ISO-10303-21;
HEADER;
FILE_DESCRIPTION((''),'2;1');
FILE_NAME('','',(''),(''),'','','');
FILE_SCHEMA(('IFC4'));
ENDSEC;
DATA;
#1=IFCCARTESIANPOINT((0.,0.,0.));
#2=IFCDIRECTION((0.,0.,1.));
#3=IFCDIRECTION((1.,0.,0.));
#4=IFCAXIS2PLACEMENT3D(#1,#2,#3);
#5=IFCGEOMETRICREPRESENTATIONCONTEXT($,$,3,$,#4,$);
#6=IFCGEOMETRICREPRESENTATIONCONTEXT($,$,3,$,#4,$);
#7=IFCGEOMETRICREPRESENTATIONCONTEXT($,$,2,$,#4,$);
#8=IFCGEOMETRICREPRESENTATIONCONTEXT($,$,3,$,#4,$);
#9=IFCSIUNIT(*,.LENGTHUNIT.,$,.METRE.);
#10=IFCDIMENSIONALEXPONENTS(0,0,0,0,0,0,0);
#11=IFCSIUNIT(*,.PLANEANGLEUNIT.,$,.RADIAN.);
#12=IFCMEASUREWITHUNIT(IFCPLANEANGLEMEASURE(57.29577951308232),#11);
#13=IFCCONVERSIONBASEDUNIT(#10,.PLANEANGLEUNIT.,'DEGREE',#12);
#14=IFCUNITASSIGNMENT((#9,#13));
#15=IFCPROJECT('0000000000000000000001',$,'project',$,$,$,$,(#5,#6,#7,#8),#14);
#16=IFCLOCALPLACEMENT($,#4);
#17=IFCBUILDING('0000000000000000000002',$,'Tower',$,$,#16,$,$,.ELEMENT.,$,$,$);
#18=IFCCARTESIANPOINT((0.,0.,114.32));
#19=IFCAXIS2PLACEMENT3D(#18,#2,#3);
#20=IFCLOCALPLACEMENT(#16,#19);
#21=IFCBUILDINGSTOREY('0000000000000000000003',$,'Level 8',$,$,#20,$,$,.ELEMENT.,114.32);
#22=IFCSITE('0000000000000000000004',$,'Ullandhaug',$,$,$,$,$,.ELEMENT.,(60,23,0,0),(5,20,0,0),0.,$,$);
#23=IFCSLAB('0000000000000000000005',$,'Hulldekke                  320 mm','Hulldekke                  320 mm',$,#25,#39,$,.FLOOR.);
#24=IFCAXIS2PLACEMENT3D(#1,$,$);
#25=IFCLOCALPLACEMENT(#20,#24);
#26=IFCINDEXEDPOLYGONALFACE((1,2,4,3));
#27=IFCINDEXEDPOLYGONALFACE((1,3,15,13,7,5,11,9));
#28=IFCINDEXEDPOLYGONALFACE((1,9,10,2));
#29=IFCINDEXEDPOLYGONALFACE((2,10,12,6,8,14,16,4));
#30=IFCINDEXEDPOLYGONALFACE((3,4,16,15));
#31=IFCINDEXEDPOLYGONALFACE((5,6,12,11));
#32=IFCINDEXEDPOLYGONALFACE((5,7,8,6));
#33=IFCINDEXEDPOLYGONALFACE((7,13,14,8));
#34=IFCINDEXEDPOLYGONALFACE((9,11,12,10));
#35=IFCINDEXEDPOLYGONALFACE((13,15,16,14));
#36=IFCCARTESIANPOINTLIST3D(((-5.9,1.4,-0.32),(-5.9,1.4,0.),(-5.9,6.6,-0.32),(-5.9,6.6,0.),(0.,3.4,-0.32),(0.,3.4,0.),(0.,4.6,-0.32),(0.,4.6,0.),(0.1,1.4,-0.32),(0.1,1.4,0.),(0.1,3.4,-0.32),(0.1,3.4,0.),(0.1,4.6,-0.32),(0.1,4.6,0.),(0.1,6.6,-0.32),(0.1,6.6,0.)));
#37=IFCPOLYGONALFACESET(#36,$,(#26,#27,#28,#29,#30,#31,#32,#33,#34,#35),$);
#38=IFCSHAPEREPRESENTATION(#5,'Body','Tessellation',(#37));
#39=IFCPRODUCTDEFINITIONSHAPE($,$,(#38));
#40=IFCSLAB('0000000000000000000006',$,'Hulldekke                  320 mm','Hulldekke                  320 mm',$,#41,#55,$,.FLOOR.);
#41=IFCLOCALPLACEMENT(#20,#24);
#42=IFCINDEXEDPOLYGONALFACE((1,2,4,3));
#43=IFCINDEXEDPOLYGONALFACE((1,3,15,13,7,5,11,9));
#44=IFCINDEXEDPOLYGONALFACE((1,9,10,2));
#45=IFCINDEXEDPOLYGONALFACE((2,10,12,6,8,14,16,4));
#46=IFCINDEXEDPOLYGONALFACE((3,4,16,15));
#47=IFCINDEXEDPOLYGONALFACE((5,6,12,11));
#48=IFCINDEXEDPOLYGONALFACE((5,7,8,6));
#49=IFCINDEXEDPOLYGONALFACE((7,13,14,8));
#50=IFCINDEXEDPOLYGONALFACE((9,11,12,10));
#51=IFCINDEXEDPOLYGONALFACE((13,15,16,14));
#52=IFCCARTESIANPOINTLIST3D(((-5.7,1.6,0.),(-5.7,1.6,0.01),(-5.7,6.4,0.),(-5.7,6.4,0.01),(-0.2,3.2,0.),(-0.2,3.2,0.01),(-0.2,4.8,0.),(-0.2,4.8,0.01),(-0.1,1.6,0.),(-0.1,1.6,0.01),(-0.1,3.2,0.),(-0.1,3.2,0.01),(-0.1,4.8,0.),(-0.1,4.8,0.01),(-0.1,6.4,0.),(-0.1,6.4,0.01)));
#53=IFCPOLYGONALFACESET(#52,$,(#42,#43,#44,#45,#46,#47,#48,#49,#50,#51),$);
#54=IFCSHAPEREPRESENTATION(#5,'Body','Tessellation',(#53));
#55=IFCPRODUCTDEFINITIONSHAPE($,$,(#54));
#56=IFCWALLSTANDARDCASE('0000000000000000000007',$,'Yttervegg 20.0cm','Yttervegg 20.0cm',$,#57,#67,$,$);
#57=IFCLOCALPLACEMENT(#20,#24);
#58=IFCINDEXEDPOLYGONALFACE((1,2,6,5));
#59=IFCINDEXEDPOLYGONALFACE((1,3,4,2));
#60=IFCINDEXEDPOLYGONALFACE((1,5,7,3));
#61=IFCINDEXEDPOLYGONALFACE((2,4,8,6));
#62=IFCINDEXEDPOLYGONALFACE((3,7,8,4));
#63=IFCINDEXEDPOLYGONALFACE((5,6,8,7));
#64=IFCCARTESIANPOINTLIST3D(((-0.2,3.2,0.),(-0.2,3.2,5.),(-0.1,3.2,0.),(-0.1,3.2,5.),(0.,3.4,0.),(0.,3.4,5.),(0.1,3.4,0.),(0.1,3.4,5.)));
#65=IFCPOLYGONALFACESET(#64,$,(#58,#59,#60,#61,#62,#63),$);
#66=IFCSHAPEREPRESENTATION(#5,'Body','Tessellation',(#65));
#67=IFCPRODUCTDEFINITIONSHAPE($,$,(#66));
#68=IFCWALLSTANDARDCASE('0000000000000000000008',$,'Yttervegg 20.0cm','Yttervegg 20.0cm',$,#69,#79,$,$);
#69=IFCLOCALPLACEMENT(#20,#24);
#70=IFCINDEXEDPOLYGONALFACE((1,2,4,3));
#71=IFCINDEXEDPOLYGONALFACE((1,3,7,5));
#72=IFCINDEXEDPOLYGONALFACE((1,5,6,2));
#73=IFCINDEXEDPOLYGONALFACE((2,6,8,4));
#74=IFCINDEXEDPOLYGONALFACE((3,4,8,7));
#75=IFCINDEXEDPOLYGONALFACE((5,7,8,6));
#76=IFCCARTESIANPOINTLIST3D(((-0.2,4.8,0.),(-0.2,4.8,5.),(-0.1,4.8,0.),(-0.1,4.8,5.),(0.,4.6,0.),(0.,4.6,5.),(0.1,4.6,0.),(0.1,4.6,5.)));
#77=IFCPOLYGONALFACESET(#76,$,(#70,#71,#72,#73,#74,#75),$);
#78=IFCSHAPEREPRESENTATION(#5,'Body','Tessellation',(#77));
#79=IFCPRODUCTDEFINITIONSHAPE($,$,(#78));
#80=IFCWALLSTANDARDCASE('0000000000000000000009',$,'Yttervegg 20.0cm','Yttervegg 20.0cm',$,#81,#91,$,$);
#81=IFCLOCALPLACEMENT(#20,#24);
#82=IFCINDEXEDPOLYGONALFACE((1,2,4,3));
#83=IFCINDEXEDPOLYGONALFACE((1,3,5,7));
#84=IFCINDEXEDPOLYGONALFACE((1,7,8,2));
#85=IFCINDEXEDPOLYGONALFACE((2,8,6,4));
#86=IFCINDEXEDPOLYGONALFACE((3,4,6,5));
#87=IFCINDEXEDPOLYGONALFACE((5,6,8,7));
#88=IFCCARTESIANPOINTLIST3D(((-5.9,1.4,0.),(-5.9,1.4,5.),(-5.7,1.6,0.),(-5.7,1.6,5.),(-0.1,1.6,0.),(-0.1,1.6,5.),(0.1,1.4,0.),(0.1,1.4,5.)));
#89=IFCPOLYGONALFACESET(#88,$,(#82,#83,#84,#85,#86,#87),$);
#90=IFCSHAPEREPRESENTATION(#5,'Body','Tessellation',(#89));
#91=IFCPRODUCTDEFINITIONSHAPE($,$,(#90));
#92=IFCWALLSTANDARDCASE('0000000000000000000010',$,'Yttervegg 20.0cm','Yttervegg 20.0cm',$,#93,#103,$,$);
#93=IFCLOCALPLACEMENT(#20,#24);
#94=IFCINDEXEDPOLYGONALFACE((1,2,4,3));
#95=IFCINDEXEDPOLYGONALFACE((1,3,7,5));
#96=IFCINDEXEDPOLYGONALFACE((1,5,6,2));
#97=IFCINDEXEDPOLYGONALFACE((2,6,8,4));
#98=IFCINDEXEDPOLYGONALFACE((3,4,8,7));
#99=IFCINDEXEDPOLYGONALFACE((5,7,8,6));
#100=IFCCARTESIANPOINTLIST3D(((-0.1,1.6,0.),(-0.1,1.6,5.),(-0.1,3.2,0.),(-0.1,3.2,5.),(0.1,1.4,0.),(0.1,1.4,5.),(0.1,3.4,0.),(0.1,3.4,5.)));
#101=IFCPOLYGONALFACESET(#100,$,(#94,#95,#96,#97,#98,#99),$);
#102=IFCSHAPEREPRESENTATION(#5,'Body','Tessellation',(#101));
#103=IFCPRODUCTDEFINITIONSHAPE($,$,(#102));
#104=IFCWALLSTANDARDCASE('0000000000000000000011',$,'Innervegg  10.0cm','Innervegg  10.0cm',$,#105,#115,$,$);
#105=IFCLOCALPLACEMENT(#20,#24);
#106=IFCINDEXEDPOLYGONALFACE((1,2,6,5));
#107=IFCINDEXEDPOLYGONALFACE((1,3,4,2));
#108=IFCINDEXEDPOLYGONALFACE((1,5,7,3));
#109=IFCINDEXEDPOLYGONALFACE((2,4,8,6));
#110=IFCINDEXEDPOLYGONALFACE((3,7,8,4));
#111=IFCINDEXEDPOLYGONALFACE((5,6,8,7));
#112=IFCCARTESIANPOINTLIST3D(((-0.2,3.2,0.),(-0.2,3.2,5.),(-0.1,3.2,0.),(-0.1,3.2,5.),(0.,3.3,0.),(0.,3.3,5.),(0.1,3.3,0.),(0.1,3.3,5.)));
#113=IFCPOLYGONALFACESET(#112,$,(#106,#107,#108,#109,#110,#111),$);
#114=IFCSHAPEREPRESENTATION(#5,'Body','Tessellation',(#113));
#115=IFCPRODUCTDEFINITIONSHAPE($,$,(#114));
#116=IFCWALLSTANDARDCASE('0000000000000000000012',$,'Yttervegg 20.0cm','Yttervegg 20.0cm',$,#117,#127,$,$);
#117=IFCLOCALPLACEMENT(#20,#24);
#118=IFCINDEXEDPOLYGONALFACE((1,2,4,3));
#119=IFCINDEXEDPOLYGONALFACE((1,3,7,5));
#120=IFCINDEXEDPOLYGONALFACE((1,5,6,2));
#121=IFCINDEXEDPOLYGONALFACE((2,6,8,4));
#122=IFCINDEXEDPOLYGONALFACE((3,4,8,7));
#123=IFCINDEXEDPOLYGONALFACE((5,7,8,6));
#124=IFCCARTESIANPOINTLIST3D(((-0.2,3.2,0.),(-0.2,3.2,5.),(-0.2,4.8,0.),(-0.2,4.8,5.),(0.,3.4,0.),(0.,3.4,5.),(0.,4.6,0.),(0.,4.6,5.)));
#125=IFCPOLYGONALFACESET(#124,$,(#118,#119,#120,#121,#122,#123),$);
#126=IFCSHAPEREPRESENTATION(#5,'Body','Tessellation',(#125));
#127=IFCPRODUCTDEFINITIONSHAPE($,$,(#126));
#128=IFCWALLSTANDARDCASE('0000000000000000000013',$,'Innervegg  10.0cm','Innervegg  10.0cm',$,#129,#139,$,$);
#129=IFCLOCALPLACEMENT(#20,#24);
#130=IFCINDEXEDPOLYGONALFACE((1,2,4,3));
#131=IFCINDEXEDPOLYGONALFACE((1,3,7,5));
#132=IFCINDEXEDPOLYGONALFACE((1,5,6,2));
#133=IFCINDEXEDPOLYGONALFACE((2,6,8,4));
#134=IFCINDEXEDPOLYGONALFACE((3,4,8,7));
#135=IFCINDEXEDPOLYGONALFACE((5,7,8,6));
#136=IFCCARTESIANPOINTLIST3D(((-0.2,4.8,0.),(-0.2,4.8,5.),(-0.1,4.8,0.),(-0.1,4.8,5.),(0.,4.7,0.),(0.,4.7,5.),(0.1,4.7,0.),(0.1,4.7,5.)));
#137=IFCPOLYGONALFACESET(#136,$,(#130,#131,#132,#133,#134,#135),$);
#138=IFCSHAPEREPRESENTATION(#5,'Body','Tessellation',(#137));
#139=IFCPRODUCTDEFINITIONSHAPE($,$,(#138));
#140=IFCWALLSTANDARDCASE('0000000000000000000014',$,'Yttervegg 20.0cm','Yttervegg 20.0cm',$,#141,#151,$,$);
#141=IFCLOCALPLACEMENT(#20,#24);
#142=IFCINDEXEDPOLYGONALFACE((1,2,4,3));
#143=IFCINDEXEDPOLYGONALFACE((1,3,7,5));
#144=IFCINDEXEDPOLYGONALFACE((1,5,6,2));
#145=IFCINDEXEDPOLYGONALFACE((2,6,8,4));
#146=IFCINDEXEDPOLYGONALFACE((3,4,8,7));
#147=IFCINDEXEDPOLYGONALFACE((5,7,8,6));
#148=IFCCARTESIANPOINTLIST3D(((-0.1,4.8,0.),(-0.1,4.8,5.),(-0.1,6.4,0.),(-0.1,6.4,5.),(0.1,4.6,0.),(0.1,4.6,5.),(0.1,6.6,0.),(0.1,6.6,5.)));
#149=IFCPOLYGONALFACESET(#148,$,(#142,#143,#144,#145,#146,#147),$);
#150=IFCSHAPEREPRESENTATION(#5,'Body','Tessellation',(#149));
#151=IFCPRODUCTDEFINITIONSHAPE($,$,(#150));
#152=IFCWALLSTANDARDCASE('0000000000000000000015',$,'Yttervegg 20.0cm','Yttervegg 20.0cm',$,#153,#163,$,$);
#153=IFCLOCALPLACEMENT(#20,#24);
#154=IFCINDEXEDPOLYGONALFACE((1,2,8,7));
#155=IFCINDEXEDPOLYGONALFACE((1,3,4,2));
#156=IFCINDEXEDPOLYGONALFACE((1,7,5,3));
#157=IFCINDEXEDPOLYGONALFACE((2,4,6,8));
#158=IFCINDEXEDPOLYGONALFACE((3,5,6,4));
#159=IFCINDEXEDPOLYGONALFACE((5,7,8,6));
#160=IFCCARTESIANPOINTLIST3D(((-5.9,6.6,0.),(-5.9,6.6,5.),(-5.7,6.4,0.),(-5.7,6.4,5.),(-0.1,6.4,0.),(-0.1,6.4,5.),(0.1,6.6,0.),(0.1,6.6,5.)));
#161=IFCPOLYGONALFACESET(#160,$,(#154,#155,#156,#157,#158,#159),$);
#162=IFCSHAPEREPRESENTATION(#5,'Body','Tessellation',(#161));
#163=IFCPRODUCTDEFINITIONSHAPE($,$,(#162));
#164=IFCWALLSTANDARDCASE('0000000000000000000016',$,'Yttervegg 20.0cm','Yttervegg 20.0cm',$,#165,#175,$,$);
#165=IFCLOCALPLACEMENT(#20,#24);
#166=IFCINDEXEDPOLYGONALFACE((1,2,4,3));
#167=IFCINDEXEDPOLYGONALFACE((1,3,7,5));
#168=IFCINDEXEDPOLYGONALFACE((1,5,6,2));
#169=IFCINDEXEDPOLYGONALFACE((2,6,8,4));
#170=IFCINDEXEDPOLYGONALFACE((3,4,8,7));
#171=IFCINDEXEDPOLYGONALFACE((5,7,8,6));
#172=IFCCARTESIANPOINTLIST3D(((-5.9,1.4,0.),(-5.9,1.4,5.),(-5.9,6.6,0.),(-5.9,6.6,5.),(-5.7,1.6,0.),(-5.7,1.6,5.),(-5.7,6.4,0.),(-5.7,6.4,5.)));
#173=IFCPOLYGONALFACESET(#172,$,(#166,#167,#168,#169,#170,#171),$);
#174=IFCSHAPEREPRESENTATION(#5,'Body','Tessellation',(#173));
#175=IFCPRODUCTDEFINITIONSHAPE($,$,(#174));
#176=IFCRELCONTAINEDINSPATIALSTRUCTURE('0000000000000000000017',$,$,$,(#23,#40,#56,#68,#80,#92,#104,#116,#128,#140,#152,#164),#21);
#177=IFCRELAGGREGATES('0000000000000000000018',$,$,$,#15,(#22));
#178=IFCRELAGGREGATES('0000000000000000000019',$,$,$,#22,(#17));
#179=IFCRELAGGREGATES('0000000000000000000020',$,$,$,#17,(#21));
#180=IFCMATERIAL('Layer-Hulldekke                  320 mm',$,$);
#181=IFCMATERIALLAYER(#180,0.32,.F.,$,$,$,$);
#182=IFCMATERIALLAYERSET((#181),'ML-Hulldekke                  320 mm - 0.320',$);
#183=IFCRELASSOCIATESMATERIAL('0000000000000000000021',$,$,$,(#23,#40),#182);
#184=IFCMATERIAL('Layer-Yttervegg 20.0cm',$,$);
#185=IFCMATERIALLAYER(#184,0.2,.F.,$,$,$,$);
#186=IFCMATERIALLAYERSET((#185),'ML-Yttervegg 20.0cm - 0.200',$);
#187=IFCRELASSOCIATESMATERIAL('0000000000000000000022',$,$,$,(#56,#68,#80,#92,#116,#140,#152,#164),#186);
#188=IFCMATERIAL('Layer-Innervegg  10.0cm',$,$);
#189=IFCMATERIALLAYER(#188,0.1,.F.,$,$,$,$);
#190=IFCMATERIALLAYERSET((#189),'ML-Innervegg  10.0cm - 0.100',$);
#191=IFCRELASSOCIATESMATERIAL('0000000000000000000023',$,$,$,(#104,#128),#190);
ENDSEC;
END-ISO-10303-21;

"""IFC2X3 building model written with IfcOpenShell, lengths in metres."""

from ifc_helpers import new_model, entity, si_unit, converted_unit, frame, origin_with_axes, place, context, project, spatial, polyline, outline, extrude, material, layer, layer_set, layer_usage, element, save


model = new_model("IFC2X3")

# Units and contexts
context_of_model_1 = context(None, 3, world=origin_with_axes())
context_of_model_2 = context(None, 3, world=origin_with_axes())
context_of_model_3 = context(None, 2, world=origin_with_axes())
context_of_model_4 = context(None, 3, world=origin_with_axes())
ifc_project = project(units=[si_unit("LENGTHUNIT", "METRE"), converted_unit("PLANEANGLEUNIT", "DEGREE", entity("IfcPlaneAngleMeasure", 57.29577951308232), si_unit("PLANEANGLEUNIT", "RADIAN"), dimensions=[0, 0, 0, 0, 0, 0, 0])], contexts=[context_of_model_1, context_of_model_2, context_of_model_3, context_of_model_4])

# Site, building, storey
site = spatial("IfcSite", under=ifc_project, Name="Ullandhaug", CompositionType="ELEMENT", RefLatitude=(60, 23, 0, 0), RefLongitude=(5, 20, 0, 0), RefElevation=0.0)
building_placement = place(None, origin_with_axes())
building = spatial("IfcBuilding", under=site, at=building_placement, Name="Tower", CompositionType="ELEMENT")
storey_placement = place(building_placement, frame((0.0, 0.0, 114.32), z_axis=(0.0, 0.0, 1.0), x_axis=(1.0, 0.0, 0.0)))
storey = spatial("IfcBuildingStorey", under=building, at=storey_placement, Name="Level 8", CompositionType="ELEMENT", Elevation=114.32)

# Slabs
ifc_material_1 = material(Name="Layer-Hulldekke                  320 mm")
ifc_layer_1 = layer(ifc_material_1, 0.32, ventilated=False)
ifc_layer_set_1 = layer_set([ifc_layer_1], Name="ML-Hulldekke                  320 mm - 0.320")
ifc_layer_usage_1 = layer_usage(ifc_layer_set_1, "AXIS2", "POSITIVE", 0.0)
slab_1_placement = place(storey_placement, frame((-5.9, 1.4, 0.0), z_axis=(0.0, 0.0, 1.0), x_axis=(1.0, 0.0, 0.0)))
element("IfcSlab", 1, at=slab_1_placement, inside=storey, material=ifc_layer_usage_1, Name="Hulldekke                  320 mm", Description="Hulldekke                  320 mm", PredefinedType="FLOOR", context=context_of_model_1, shape_type="SweptSolid", body=[
    extrude(outline(polyline([(0.0, 0.0), (6.0, 0.0), (6.0, 2.0), (5.9, 2.0), (5.9, 3.2), (6.0, 3.2), (6.0, 5.2), (0.0, 5.2), (0.0, 0.0)])), origin_with_axes(), (0.0, 0.0, -1.0), 0.32),
])
slab_2_placement = place(storey_placement, frame((-5.7, 1.6, 0.0), z_axis=(0.0, 0.0, 1.0), x_axis=(1.0, 0.0, 0.0)))
element("IfcSlab", 2, at=slab_2_placement, inside=storey, material=ifc_layer_usage_1, Name="Hulldekke                  320 mm", Description="Hulldekke                  320 mm", PredefinedType="FLOOR", context=context_of_model_1, shape_type="SweptSolid", body=[
    extrude(outline(polyline([(0.0, 0.0), (5.6, 0.0), (5.6, 1.6), (5.5, 1.6), (5.5, 3.2), (5.6, 3.2), (5.6, 4.8), (0.0, 4.8), (0.0, 0.0)])), origin_with_axes(), (0.0, 0.0, 1.0), 0.01),
])

# Walls
ifc_material_2 = material(Name="Layer-Yttervegg 20.0cm")
ifc_layer_2 = layer(ifc_material_2, 0.2, ventilated=False)
ifc_layer_set_2 = layer_set([ifc_layer_2], Name="ML-Yttervegg 20.0cm - 0.200")
ifc_layer_usage_2 = layer_usage(ifc_layer_set_2, "AXIS2", "POSITIVE", 0.0)
wall_1_placement = place(storey_placement, frame((0.1, 3.4, 0.0), z_axis=(0.0, 0.0, 1.0), x_axis=(-1.0, 0.0, 0.0)))
element("IfcWallStandardCase", 3, at=wall_1_placement, inside=storey, material=ifc_layer_usage_2, Name="Yttervegg 20.0cm", Description="Yttervegg 20.0cm", context=context_of_model_1, shape_type="SweptSolid", body=[
    extrude(outline(polyline([(0.0, 0.0), (0.1, 0.0), (0.3, 0.2), (0.2, 0.2), (0.0, 0.0)])), frame((0.0, 0.0, 0.0), z_axis=(0.0, 0.0, 1.0), x_axis=(1.0, 0.0, 0.0)), (0.0, 0.0, 1.0), 5.0),
])
wall_2_placement = place(storey_placement, frame((0.0, 4.6, 0.0), z_axis=(0.0, 0.0, 1.0), x_axis=(1.0, 0.0, 0.0)))
element("IfcWallStandardCase", 4, at=wall_2_placement, inside=storey, material=ifc_layer_usage_2, Name="Yttervegg 20.0cm", Description="Yttervegg 20.0cm", context=context_of_model_1, shape_type="SweptSolid", body=[
    extrude(outline(polyline([(0.0, 0.0), (0.1, 0.0), (-0.1, 0.2), (-0.2, 0.2), (0.0, 0.0)])), origin_with_axes(), (0.0, 0.0, 1.0), 5.0),
])
wall_3_placement = place(storey_placement, frame((-5.9, 1.4, 0.0), z_axis=(0.0, 0.0, 1.0), x_axis=(1.0, 0.0, 0.0)))
element("IfcWallStandardCase", 5, at=wall_3_placement, inside=storey, material=ifc_layer_usage_2, Name="Yttervegg 20.0cm", Description="Yttervegg 20.0cm", context=context_of_model_1, shape_type="SweptSolid", body=[
    extrude(outline(polyline([(0.0, 0.0), (6.0, 0.0), (5.8, 0.2), (0.2, 0.2), (0.0, 0.0)])), origin_with_axes(), (0.0, 0.0, 1.0), 5.0),
])
wall_4_placement = place(storey_placement, frame((0.1, 1.4, 0.0), z_axis=(0.0, 0.0, 1.0), x_axis=(0.0, 1.0, 0.0)))
element("IfcWallStandardCase", 6, at=wall_4_placement, inside=storey, material=ifc_layer_usage_2, Name="Yttervegg 20.0cm", Description="Yttervegg 20.0cm", context=context_of_model_1, shape_type="SweptSolid", body=[
    extrude(outline(polyline([(0.0, 0.0), (2.0, 0.0), (1.8, 0.2), (0.2, 0.2), (0.0, 0.0)])), frame((0.0, 0.0, 0.0), z_axis=(0.0, 0.0, 1.0), x_axis=(1.0, 0.0, 0.0)), (0.0, 0.0, 1.0), 5.0),
])
ifc_material_3 = material(Name="Layer-Innervegg  10.0cm")
ifc_layer_3 = layer(ifc_material_3, 0.1, ventilated=False)
ifc_layer_set_3 = layer_set([ifc_layer_3], Name="ML-Innervegg  10.0cm - 0.100")
ifc_layer_usage_3 = layer_usage(ifc_layer_set_3, "AXIS2", "POSITIVE", 0.0)
wall_5_placement = place(storey_placement, frame((0.1, 3.3, 0.0), z_axis=(0.0, 0.0, 1.0), x_axis=(-1.0, 0.0, 0.0)))
element("IfcWallStandardCase", 7, at=wall_5_placement, inside=storey, material=ifc_layer_usage_3, Name="Innervegg  10.0cm", Description="Innervegg  10.0cm", context=context_of_model_1, shape_type="SweptSolid", body=[
    extrude(outline(polyline([(0.0, 0.0), (0.1, 0.0), (0.3, 0.1), (0.2, 0.1), (0.0, 0.0)])), frame((0.0, 0.0, 0.0), z_axis=(0.0, 0.0, 1.0), x_axis=(1.0, 0.0, 0.0)), (0.0, 0.0, 1.0), 5.0),
])
wall_6_placement = place(storey_placement, frame((0.0, 3.4, 0.0), z_axis=(0.0, 0.0, 1.0), x_axis=(0.0, 1.0, 0.0)))
element("IfcWallStandardCase", 8, at=wall_6_placement, inside=storey, material=ifc_layer_usage_2, Name="Yttervegg 20.0cm", Description="Yttervegg 20.0cm", context=context_of_model_1, shape_type="SweptSolid", body=[
    extrude(outline(polyline([(0.0, 0.0), (1.2, 0.0), (1.4, 0.2), (-0.2, 0.2), (0.0, 0.0)])), frame((0.0, 0.0, 0.0), z_axis=(0.0, 0.0, 1.0), x_axis=(1.0, 0.0, 0.0)), (0.0, 0.0, 1.0), 5.0),
])
wall_7_placement = place(storey_placement, frame((0.0, 4.7, 0.0), z_axis=(0.0, 0.0, 1.0), x_axis=(1.0, 0.0, 0.0)))
element("IfcWallStandardCase", 9, at=wall_7_placement, inside=storey, material=ifc_layer_usage_3, Name="Innervegg  10.0cm", Description="Innervegg  10.0cm", context=context_of_model_1, shape_type="SweptSolid", body=[
    extrude(outline(polyline([(0.0, 0.0), (0.1, 0.0), (-0.1, 0.1), (-0.2, 0.1), (0.0, 0.0)])), origin_with_axes(), (0.0, 0.0, 1.0), 5.0),
])
wall_8_placement = place(storey_placement, frame((0.1, 4.6, 0.0), z_axis=(0.0, 0.0, 1.0), x_axis=(0.0, 1.0, 0.0)))
element("IfcWallStandardCase", 10, at=wall_8_placement, inside=storey, material=ifc_layer_usage_2, Name="Yttervegg 20.0cm", Description="Yttervegg 20.0cm", context=context_of_model_1, shape_type="SweptSolid", body=[
    extrude(outline(polyline([(0.0, 0.0), (2.0, 0.0), (1.8, 0.2), (0.2, 0.2), (0.0, 0.0)])), frame((0.0, 0.0, 0.0), z_axis=(0.0, 0.0, 1.0), x_axis=(1.0, 0.0, 0.0)), (0.0, 0.0, 1.0), 5.0),
])
wall_9_placement = place(storey_placement, frame((0.1, 6.6, 0.0), z_axis=(0.0, 0.0, 1.0), x_axis=(-1.0, 0.0, 0.0)))
element("IfcWallStandardCase", 11, at=wall_9_placement, inside=storey, material=ifc_layer_usage_2, Name="Yttervegg 20.0cm", Description="Yttervegg 20.0cm", context=context_of_model_1, shape_type="SweptSolid", body=[
    extrude(outline(polyline([(0.0, 0.0), (6.0, 0.0), (5.8, 0.2), (0.2, 0.2), (0.0, 0.0)])), frame((0.0, 0.0, 0.0), z_axis=(0.0, 0.0, 1.0), x_axis=(1.0, 0.0, 0.0)), (0.0, 0.0, 1.0), 5.0),
])
wall_10_placement = place(storey_placement, frame((-5.9, 6.6, 0.0), z_axis=(0.0, 0.0, 1.0), x_axis=(0.0, -1.0, 0.0)))
element("IfcWallStandardCase", 12, at=wall_10_placement, inside=storey, material=ifc_layer_usage_2, Name="Yttervegg 20.0cm", Description="Yttervegg 20.0cm", context=context_of_model_1, shape_type="SweptSolid", body=[
    extrude(outline(polyline([(0.0, 0.0), (5.2, 0.0), (5.0, 0.2), (0.2, 0.2), (0.0, 0.0)])), frame((0.0, 0.0, 0.0), z_axis=(0.0, 0.0, 1.0), x_axis=(1.0, 0.0, 0.0)), (0.0, 0.0, 1.0), 5.0),
])

save(model, "model.ifc")
